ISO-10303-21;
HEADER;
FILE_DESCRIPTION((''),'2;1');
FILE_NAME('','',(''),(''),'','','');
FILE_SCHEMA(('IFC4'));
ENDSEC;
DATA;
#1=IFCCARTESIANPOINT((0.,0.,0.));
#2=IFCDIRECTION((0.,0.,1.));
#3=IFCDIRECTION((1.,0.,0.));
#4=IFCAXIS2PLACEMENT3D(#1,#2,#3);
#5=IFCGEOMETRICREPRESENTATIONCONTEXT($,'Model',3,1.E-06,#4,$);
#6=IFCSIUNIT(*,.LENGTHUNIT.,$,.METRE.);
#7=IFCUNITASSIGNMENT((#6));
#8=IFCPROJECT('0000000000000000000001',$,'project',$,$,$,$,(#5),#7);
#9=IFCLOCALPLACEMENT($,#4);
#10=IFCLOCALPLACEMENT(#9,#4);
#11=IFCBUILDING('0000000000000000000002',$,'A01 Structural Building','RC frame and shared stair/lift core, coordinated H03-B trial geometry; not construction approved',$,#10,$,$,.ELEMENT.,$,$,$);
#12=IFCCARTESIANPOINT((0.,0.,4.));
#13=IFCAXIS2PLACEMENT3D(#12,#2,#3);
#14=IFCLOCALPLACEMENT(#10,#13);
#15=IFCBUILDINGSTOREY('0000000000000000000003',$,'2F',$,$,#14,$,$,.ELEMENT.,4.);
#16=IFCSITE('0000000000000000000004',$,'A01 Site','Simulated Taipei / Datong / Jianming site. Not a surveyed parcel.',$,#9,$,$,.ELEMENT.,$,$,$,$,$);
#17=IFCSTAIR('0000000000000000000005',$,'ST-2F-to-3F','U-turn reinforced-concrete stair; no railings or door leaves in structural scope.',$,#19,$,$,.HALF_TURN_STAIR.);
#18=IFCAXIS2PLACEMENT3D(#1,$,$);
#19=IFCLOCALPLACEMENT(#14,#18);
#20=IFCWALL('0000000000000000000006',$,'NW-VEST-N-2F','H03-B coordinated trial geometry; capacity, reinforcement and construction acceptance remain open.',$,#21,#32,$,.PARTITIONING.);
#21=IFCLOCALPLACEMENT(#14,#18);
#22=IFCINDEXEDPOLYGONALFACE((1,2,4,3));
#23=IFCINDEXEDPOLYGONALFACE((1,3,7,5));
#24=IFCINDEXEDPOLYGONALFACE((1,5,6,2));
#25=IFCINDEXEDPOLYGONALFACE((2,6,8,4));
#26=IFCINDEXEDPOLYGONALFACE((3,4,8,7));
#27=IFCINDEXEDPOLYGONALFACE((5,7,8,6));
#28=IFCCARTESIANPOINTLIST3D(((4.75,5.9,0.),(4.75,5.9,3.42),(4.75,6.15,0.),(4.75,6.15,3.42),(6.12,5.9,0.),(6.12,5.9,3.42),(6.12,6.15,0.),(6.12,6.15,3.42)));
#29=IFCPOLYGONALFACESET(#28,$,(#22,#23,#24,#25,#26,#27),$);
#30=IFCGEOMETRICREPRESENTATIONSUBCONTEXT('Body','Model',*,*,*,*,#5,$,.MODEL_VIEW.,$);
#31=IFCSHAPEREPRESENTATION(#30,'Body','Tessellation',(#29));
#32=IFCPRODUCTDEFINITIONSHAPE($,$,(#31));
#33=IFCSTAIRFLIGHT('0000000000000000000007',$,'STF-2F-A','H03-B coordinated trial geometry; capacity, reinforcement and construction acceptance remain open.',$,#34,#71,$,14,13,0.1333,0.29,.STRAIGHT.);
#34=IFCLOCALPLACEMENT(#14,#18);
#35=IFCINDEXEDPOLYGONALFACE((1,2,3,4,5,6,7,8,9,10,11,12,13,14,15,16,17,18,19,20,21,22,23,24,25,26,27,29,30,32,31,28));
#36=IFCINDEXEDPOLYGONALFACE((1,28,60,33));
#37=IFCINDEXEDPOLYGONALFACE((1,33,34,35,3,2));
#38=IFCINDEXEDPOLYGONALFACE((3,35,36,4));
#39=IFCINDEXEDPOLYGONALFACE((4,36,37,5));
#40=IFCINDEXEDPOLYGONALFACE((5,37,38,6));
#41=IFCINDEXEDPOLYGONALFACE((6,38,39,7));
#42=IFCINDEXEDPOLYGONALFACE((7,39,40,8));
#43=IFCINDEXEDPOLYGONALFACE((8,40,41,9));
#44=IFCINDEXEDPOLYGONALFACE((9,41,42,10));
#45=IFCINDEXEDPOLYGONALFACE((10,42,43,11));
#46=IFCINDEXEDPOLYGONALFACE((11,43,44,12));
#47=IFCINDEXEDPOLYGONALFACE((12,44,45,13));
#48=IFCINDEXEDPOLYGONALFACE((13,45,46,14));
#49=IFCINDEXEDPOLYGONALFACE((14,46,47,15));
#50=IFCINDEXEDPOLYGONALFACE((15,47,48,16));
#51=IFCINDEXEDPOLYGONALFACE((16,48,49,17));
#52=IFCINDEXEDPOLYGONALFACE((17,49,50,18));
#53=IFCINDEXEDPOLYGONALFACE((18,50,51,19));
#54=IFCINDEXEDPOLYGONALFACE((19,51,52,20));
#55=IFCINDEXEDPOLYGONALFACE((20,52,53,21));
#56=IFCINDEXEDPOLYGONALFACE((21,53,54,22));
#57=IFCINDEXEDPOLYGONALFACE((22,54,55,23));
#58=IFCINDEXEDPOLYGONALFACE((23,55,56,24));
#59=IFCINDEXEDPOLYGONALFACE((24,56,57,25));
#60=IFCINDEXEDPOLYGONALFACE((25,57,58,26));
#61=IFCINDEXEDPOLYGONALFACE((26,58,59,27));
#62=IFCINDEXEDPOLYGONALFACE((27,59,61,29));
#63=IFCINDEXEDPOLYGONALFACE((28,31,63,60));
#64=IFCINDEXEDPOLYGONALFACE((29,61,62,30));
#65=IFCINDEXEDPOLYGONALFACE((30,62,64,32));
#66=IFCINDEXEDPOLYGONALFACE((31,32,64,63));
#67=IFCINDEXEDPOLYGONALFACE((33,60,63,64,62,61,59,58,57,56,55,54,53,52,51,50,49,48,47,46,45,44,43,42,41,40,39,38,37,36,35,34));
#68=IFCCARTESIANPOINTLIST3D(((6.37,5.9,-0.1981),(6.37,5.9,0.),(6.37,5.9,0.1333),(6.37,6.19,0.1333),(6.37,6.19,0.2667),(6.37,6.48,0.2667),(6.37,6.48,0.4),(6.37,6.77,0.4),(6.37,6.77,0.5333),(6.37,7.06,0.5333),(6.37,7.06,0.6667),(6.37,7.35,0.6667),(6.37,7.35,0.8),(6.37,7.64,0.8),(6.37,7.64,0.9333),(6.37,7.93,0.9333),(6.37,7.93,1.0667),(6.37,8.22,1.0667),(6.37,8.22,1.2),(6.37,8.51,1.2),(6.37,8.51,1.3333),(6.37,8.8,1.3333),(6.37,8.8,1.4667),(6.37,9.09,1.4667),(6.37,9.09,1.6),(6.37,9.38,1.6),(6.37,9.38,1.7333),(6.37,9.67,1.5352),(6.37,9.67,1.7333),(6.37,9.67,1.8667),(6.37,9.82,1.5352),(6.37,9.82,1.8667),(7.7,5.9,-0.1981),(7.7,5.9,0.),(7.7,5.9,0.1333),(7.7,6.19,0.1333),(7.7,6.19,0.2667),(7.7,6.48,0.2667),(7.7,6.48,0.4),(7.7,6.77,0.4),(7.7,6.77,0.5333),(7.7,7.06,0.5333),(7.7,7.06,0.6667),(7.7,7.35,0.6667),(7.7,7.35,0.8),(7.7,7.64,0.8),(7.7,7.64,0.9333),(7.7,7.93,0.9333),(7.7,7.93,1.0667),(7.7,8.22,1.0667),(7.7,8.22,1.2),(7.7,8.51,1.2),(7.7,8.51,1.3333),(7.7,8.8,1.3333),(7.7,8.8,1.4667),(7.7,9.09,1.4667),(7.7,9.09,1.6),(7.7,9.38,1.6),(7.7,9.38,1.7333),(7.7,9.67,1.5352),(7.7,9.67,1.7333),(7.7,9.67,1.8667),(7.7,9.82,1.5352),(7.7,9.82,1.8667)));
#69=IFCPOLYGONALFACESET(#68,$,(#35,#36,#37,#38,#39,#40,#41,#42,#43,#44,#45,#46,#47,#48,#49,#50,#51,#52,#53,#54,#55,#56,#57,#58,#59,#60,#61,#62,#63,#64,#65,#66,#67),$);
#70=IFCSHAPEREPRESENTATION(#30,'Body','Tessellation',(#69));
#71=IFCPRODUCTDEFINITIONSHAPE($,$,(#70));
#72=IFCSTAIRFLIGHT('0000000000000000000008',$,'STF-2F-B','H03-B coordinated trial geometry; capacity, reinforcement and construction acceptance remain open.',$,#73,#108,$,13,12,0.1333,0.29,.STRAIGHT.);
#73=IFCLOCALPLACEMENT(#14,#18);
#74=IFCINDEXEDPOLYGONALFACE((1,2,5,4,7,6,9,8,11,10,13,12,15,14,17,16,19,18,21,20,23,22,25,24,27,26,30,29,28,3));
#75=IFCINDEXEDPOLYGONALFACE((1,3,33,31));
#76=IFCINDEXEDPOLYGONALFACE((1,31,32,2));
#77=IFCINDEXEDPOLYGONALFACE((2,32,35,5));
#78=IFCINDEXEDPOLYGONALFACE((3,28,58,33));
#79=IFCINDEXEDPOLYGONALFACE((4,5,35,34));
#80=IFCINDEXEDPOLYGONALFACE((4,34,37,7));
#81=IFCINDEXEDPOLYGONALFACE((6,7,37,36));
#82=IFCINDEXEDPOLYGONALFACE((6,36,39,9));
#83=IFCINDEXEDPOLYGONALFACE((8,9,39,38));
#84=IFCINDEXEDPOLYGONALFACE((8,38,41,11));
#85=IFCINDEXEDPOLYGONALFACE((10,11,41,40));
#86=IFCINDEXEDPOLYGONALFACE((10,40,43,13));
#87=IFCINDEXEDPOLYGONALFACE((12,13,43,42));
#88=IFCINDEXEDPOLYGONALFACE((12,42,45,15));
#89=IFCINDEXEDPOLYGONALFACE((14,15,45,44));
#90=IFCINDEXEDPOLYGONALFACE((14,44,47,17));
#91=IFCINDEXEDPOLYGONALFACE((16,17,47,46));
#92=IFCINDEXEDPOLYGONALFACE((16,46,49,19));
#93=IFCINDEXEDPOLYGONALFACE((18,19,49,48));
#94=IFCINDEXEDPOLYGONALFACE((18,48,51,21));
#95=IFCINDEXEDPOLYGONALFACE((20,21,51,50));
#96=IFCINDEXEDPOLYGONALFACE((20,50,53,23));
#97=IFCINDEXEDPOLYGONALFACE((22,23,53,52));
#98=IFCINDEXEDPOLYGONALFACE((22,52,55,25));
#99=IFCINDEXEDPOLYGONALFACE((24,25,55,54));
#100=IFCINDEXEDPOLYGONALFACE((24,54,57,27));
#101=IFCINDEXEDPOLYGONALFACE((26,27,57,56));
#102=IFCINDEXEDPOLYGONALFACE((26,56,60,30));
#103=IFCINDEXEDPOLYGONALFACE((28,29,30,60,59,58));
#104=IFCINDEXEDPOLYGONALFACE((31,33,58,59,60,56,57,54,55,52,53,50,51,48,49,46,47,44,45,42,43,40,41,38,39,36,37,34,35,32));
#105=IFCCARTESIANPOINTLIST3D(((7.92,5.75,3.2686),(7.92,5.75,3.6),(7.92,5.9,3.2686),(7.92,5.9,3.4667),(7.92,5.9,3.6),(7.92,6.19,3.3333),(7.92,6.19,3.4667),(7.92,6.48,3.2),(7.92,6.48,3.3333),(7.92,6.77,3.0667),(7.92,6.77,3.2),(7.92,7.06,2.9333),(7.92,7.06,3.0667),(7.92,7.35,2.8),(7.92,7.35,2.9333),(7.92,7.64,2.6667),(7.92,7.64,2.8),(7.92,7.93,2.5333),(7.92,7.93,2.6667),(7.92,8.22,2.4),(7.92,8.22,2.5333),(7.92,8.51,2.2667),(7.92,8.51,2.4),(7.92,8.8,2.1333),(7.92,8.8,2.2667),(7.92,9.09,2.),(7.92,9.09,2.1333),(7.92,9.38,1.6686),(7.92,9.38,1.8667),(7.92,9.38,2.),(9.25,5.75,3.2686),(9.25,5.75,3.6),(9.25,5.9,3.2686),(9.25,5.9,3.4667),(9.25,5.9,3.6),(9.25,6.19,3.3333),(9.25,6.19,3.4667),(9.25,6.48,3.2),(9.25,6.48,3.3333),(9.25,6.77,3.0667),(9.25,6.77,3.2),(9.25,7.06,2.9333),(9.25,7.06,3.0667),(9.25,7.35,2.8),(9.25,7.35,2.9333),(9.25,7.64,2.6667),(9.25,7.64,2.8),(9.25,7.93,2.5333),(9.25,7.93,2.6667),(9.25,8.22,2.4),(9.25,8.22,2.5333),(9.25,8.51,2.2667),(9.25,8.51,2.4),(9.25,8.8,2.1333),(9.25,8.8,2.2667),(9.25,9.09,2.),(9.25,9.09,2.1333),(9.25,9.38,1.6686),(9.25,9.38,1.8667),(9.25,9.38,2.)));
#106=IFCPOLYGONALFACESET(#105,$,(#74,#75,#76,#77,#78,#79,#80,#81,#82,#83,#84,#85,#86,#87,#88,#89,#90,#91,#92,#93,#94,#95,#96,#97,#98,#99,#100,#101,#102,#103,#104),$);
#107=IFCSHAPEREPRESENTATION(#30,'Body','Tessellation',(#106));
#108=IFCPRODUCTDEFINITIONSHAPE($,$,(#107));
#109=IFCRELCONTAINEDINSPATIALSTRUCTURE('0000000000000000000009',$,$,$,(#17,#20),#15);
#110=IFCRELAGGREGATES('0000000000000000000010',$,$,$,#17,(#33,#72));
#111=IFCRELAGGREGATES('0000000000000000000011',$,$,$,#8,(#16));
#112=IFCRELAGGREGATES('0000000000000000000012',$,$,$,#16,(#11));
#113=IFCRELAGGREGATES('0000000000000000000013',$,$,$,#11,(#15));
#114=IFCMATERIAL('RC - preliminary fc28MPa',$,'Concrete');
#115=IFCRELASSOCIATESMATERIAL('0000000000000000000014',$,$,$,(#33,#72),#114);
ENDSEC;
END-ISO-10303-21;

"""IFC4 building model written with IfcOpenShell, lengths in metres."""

from ifc_helpers import new_model, si_unit, frame, origin_with_axes, place, context, subcontext, project, spatial, polyline, outline, extrude, material, element, aggregate, save


model = new_model("IFC4")

# Units and contexts
model_context = context("Model", 3, precision=1e-06, world=origin_with_axes())
body_context = subcontext(model_context, "Body", "Model", "MODEL_VIEW")
ifc_project = project(units=[si_unit("LENGTHUNIT", "METRE")], contexts=[model_context])

# Site, building, storey
site_placement = place(None, origin_with_axes())
site = spatial("IfcSite", under=ifc_project, at=site_placement, Name="A01 Site", Description="Simulated Taipei / Datong / Jianming site. Not a surveyed parcel.", CompositionType="ELEMENT")
building_placement = place(site_placement, origin_with_axes())
building = spatial("IfcBuilding", under=site, at=building_placement, Name="A01 Structural Building", Description="RC frame and shared stair/lift core, coordinated H03-B trial geometry; not construction approved", CompositionType="ELEMENT")
storey_placement = place(building_placement, frame((0.0, 0.0, 4.0), z_axis=(0.0, 0.0, 1.0), x_axis=(1.0, 0.0, 0.0)))
storey = spatial("IfcBuildingStorey", under=building, at=storey_placement, Name="2F", CompositionType="ELEMENT", Elevation=4.0)

# Shared definitions
ifc_material = material(Name="RC - preliminary fc28MPa", Category="Concrete")

# Stair
stair_placement = place(storey_placement, origin_with_axes())
stair = element("IfcStair", 1, at=stair_placement, inside=storey, Name="ST-2F-to-3F", Description="U-turn reinforced-concrete stair; no railings or door leaves in structural scope.", PredefinedType="HALF_TURN_STAIR")
placement = place(None, origin_with_axes())

# Wall
element("IfcWall", 2, at=placement, inside=storey, Name="NW-VEST-N-2F", Description="H03-B coordinated trial geometry; capacity, reinforcement and construction acceptance remain open.", PredefinedType="PARTITIONING", context=body_context, shape_type="SweptSolid", body=[
    extrude(outline(polyline([(6.12, 5.9), (6.12, 6.15), (4.75, 6.15), (4.75, 5.9), (6.12, 5.9)])), frame((0.0, 0.0, 4.0), z_axis=(0.0, 0.0, 1.0), x_axis=(1.0, 0.0, 0.0)), (0.0, 0.0, 1.0), 3.42),
])

# Stair flights
stair_flight_1 = element("IfcStairFlight", 3, at=placement, material=ifc_material, Name="STF-2F-A", Description="H03-B coordinated trial geometry; capacity, reinforcement and construction acceptance remain open.", NumberOfRisers=14, NumberOfTreads=13, PredefinedType="STRAIGHT", RiserHeight=0.1333, TreadLength=0.29, context=body_context, shape_type="SweptSolid", body=[
    extrude(outline(polyline([(0.0, 0.0), (0.0, 0.1333), (0.29, 0.1333), (0.29, 0.2667), (0.58, 0.2667), (0.58, 0.4), (0.87, 0.4), (0.87, 0.5333), (1.16, 0.5333), (1.16, 0.6667), (1.45, 0.6667), (1.45, 0.8), (1.74, 0.8), (1.74, 0.9333), (2.03, 0.9333), (2.03, 1.0667), (2.32, 1.0667), (2.32, 1.2), (2.61, 1.2), (2.61, 1.3333), (2.9, 1.3333), (2.9, 1.4667), (3.19, 1.4667), (3.19, 1.6), (3.48, 1.6), (3.48, 1.7333), (3.77, 1.7333), (3.77, 1.8667), (3.92, 1.8667), (3.92, 1.5352), (3.77, 1.5352), (0.0, -0.1981), (0.0, 0.0)])), frame((6.37, 5.9, 4.0), z_axis=(1.0, 0.0, 0.0), x_axis=(0.0, 1.0, 0.0)), (0.0, 0.0, 1.0), 1.33),
])
stair_flight_2 = element("IfcStairFlight", 4, at=placement, material=ifc_material, Name="STF-2F-B", Description="H03-B coordinated trial geometry; capacity, reinforcement and construction acceptance remain open.", NumberOfRisers=13, NumberOfTreads=12, PredefinedType="STRAIGHT", RiserHeight=0.1333, TreadLength=0.29, context=body_context, shape_type="SweptSolid", body=[
    extrude(outline(polyline([(0.0, 0.0), (0.0, 0.1333), (0.29, 0.1333), (0.29, 0.2667), (0.58, 0.2667), (0.58, 0.4), (0.87, 0.4), (0.87, 0.5333), (1.16, 0.5333), (1.16, 0.6667), (1.45, 0.6667), (1.45, 0.8), (1.74, 0.8), (1.74, 0.9333), (2.03, 0.9333), (2.03, 1.0667), (2.32, 1.0667), (2.32, 1.2), (2.61, 1.2), (2.61, 1.3333), (2.9, 1.3333), (2.9, 1.4667), (3.19, 1.4667), (3.19, 1.6), (3.48, 1.6), (3.48, 1.7333), (3.63, 1.7333), (3.63, 1.4019), (3.48, 1.4019), (0.0, -0.1981), (0.0, 0.0)])), frame((9.25, 9.38, 5.8667), z_axis=(-1.0, 0.0, 0.0), x_axis=(0.0, -1.0, 0.0)), (0.0, 0.0, 1.0), 1.33),
])
aggregate(stair, [stair_flight_1, stair_flight_2])

save(model, "model.ifc")
